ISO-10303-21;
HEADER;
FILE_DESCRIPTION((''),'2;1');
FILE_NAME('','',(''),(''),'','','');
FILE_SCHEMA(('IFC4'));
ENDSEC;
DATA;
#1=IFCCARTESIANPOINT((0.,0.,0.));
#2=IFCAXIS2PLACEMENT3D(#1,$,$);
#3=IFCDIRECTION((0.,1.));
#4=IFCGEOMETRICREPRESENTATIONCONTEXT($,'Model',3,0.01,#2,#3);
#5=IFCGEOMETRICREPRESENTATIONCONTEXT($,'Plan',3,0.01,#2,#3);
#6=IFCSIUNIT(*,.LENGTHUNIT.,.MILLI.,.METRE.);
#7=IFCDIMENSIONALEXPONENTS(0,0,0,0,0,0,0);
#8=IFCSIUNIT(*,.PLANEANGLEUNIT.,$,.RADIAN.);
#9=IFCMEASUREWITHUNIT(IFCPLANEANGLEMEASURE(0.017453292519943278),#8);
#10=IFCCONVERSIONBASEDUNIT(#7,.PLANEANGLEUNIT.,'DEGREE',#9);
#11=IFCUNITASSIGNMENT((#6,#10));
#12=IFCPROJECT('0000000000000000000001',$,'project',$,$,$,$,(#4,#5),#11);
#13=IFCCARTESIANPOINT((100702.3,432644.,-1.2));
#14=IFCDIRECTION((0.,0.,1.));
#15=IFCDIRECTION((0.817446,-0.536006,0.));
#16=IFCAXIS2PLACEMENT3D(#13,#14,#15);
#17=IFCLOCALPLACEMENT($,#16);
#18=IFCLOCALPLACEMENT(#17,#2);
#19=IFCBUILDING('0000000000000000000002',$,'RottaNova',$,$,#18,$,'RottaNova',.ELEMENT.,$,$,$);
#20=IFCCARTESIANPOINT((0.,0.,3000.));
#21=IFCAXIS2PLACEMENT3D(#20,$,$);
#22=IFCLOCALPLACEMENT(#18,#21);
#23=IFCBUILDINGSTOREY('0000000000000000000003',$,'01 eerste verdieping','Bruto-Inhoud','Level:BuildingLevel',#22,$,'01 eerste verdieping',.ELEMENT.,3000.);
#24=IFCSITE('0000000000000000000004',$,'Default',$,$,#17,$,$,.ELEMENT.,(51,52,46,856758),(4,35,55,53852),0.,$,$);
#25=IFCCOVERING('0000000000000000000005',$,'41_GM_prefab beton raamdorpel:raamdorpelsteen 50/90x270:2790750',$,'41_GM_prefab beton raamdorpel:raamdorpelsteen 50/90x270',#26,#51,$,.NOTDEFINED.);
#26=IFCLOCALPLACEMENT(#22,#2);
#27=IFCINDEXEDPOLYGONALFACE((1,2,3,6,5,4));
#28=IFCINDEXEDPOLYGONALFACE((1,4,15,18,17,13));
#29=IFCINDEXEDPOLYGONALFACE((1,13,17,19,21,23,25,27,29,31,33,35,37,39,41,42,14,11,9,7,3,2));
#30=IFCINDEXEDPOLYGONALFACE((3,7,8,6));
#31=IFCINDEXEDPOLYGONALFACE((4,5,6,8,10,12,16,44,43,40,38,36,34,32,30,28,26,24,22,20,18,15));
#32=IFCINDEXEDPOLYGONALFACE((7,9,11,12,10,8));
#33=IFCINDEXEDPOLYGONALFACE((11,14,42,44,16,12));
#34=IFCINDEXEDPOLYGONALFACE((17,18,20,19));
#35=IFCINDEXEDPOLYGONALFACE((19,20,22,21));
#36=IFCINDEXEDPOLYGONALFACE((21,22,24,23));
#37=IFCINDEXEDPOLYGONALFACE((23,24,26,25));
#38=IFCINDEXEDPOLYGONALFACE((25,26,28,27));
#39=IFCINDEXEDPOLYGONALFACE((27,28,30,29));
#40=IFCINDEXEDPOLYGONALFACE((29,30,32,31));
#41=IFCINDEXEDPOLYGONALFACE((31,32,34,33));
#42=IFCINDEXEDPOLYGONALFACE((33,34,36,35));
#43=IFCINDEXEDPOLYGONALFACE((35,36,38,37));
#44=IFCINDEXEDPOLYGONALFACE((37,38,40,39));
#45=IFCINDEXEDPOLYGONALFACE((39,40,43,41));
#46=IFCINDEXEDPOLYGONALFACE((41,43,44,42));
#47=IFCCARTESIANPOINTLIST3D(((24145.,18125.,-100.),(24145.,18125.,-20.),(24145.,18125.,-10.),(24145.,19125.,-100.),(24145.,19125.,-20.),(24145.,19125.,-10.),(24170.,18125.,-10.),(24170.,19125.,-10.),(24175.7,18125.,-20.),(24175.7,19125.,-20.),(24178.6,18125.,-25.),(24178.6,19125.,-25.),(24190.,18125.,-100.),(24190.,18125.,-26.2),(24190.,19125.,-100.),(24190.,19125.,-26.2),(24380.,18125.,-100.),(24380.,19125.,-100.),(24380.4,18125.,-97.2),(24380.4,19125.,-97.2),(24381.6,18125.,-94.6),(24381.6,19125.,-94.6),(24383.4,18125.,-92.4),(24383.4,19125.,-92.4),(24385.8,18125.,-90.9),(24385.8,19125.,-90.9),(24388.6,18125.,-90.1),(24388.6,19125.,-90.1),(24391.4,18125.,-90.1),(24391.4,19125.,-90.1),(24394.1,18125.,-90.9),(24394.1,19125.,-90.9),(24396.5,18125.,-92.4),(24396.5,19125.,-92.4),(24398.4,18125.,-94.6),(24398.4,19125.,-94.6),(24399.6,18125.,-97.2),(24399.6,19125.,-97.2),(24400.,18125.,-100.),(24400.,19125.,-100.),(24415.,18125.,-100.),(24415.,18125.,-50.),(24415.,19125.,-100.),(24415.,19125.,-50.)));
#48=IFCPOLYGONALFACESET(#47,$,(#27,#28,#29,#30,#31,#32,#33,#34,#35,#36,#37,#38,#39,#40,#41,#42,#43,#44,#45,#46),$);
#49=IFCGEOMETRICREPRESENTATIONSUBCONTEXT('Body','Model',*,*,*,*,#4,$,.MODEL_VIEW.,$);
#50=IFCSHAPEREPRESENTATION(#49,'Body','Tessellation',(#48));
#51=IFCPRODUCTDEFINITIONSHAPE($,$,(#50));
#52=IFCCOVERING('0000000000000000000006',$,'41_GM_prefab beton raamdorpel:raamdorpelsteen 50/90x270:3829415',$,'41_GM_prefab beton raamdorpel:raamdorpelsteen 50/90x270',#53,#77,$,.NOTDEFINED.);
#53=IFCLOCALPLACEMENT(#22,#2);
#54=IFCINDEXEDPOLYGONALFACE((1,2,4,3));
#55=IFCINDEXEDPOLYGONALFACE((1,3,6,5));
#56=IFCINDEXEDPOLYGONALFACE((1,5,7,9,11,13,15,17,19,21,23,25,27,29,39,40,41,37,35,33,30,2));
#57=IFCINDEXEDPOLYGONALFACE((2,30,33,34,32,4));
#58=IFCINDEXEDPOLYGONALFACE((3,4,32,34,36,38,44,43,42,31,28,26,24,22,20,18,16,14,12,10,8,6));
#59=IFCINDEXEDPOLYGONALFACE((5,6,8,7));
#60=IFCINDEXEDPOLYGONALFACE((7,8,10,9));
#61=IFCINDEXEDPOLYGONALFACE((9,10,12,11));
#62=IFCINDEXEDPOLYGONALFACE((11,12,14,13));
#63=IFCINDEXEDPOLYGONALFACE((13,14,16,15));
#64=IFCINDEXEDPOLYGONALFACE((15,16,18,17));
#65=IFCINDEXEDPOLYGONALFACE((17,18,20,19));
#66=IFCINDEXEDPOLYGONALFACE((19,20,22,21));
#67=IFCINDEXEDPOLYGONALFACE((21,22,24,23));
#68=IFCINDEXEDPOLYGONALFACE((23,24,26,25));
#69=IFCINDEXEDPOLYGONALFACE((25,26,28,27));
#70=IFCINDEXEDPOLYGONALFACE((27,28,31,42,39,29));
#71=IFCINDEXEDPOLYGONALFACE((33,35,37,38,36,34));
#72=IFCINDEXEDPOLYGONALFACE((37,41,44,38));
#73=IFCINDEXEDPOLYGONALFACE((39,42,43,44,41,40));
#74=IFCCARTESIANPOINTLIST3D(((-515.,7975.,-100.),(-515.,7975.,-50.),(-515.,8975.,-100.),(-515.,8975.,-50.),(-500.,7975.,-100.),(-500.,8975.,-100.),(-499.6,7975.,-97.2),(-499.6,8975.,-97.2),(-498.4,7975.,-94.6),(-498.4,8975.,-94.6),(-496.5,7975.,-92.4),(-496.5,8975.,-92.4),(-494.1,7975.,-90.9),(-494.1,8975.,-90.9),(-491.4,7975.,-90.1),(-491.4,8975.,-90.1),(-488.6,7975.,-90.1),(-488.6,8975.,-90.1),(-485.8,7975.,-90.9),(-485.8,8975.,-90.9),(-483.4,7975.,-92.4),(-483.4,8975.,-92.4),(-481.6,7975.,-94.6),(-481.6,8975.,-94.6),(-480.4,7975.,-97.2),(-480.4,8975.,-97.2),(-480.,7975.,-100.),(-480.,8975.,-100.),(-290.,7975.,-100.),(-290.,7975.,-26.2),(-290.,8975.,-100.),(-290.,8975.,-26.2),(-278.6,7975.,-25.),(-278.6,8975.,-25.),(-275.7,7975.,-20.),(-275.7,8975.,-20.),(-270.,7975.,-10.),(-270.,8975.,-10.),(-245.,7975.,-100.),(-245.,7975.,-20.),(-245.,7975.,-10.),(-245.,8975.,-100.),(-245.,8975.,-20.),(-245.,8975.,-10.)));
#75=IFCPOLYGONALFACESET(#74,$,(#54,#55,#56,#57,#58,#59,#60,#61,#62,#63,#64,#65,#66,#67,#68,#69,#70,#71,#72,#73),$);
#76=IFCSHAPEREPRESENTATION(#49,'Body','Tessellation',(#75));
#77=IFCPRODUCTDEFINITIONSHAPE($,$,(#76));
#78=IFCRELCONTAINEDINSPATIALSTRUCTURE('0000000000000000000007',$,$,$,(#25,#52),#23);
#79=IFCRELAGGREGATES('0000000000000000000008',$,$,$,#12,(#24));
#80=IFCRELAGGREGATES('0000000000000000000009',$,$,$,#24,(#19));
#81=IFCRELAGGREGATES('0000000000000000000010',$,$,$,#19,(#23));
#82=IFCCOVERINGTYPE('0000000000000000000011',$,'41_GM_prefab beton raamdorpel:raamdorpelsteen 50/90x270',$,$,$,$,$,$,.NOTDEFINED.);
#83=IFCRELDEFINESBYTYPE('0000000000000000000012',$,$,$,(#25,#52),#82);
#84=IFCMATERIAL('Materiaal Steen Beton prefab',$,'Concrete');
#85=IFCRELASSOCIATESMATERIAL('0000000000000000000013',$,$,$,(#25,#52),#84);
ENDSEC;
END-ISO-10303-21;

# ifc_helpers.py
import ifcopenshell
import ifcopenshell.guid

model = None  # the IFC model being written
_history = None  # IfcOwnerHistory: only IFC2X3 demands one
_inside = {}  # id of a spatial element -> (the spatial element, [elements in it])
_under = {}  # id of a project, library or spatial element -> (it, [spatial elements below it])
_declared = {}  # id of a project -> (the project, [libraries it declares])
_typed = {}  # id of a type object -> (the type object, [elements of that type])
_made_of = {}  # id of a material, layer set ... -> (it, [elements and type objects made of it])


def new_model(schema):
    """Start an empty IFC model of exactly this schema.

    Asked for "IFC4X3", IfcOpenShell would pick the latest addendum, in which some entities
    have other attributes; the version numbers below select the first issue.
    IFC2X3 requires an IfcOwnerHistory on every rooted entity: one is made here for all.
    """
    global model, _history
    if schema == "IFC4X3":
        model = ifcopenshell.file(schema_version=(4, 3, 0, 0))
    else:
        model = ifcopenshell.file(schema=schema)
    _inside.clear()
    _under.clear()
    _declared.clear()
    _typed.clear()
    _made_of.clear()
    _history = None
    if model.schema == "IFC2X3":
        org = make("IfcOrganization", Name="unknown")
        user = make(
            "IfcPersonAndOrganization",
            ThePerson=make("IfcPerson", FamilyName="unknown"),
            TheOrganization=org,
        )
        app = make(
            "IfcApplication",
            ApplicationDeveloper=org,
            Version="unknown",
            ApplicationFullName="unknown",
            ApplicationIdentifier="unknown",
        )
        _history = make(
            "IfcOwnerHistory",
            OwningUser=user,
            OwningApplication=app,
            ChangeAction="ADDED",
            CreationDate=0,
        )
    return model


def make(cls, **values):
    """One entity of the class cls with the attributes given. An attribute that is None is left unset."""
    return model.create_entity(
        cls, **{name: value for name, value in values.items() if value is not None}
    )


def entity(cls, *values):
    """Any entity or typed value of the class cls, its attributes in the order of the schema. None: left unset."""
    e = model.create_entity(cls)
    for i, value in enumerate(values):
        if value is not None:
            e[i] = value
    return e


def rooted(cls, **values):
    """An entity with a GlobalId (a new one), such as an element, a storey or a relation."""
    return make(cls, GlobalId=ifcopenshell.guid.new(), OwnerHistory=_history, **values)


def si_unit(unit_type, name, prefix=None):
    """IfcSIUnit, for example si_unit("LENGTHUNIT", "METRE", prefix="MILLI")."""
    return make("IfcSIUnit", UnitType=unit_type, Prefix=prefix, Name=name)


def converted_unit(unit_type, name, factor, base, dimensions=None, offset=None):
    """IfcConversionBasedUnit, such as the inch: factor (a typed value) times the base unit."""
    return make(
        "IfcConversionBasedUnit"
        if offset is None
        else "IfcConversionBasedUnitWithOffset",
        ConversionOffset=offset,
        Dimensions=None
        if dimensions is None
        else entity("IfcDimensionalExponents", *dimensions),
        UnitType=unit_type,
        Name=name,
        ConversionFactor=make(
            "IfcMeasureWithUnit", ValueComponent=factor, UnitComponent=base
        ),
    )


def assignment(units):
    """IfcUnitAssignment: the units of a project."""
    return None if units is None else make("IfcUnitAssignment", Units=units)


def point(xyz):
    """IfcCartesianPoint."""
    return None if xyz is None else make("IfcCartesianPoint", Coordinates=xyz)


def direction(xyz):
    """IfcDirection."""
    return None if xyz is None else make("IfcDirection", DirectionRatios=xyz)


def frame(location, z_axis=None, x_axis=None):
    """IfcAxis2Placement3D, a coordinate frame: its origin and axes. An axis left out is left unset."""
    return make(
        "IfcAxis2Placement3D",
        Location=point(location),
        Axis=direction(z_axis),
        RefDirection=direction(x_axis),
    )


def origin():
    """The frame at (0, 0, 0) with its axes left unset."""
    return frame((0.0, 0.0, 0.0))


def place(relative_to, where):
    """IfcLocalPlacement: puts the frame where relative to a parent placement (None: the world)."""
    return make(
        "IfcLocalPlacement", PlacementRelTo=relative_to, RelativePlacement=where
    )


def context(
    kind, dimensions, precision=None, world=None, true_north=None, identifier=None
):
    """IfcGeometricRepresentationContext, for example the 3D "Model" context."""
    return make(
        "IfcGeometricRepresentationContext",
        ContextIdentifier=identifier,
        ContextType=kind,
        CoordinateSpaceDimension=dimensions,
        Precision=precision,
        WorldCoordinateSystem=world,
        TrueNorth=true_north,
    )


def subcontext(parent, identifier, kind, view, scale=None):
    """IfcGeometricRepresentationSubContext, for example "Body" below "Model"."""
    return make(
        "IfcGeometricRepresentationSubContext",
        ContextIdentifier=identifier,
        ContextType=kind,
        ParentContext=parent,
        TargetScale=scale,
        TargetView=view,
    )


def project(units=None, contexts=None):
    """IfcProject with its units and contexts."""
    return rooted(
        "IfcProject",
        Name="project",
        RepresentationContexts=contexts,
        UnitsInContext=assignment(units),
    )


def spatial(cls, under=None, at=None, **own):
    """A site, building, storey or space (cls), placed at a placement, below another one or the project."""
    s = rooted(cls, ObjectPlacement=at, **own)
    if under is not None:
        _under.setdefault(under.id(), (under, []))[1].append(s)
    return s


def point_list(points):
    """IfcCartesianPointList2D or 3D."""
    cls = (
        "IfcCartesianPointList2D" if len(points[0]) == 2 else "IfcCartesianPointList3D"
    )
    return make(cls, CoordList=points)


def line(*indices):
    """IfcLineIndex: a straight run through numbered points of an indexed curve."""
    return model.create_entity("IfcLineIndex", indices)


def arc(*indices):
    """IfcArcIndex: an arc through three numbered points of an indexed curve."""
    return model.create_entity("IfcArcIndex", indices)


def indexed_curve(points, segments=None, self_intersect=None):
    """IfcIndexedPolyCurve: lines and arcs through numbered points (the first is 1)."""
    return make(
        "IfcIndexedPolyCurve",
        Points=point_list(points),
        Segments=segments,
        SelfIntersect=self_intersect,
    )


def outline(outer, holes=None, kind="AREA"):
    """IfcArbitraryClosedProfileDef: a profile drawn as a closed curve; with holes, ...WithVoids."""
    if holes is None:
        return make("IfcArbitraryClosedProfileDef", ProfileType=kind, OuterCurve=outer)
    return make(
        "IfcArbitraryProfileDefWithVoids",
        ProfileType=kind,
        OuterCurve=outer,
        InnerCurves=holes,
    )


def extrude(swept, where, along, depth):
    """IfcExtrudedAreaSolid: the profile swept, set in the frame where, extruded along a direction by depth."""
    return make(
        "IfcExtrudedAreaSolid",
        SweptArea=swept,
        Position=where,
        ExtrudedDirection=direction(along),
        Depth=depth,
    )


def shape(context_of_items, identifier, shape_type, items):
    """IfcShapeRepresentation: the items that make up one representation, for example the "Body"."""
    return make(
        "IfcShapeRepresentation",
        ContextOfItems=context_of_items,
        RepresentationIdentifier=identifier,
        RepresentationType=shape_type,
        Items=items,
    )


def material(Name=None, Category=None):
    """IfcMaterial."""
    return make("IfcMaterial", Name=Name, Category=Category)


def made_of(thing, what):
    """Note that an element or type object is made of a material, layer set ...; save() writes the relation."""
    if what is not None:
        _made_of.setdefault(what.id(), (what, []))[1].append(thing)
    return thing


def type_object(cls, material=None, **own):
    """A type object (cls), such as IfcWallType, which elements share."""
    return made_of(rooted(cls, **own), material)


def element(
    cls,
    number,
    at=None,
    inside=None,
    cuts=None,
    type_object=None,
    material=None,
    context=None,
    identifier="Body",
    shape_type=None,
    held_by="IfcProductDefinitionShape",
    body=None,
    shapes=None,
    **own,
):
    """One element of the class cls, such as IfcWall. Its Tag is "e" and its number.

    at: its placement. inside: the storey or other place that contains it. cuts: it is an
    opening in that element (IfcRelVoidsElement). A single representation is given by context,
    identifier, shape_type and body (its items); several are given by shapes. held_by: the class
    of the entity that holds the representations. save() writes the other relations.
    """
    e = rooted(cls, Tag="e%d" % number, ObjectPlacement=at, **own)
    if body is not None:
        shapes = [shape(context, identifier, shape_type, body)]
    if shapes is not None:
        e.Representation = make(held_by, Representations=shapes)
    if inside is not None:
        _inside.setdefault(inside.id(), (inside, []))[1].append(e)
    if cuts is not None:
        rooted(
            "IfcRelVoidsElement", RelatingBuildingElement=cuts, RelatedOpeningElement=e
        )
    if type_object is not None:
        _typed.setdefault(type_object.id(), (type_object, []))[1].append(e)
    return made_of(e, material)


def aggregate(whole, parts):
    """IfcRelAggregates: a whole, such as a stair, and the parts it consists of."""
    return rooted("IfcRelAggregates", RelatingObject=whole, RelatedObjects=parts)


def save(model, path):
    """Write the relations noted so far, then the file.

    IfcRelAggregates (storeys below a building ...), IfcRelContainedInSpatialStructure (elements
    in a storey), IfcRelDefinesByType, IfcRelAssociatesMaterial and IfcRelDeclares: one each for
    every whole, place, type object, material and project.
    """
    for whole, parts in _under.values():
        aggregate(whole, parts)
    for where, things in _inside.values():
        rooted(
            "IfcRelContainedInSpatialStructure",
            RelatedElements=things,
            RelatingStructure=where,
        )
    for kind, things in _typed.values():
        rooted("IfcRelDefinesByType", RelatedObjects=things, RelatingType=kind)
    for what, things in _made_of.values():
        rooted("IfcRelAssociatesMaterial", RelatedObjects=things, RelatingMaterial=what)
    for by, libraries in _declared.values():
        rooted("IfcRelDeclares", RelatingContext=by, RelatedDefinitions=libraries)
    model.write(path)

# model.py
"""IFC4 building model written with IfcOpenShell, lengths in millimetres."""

from ifc_helpers import new_model, entity, si_unit, converted_unit, direction, frame, origin, place, context, subcontext, project, spatial, line, arc, indexed_curve, outline, extrude, material, type_object, element, save


model = new_model("IFC4")

# Units and contexts
model_context = context("Model", 3, precision=0.01, world=origin(), true_north=direction((0.0, 1.0)))
plan_context = context("Plan", 3, precision=0.01, world=origin(), true_north=direction((0.0, 1.0)))
body_context = subcontext(model_context, "Body", "Model", "MODEL_VIEW")
ifc_project = project(units=[si_unit("LENGTHUNIT", "METRE", prefix="MILLI"), converted_unit("PLANEANGLEUNIT", "DEGREE", entity("IfcPlaneAngleMeasure", 0.017453292519943278), si_unit("PLANEANGLEUNIT", "RADIAN"), dimensions=[0, 0, 0, 0, 0, 0, 0])], contexts=[model_context, plan_context])

# Site, building, storey
site_placement = place(None, frame((100702.3, 432644.0, -1.2), z_axis=(0.0, 0.0, 1.0), x_axis=(0.817446, -0.536006, 0.0)))
site = spatial("IfcSite", under=ifc_project, at=site_placement, Name="Default", CompositionType="ELEMENT", RefLatitude=(51, 52, 46, 856758), RefLongitude=(4, 35, 55, 53852), RefElevation=0.0)
building_placement = place(site_placement, origin())
building = spatial("IfcBuilding", under=site, at=building_placement, Name="RottaNova", LongName="RottaNova", CompositionType="ELEMENT")
storey_placement = place(building_placement, frame((0.0, 0.0, 3000.0)))
storey = spatial("IfcBuildingStorey", under=building, at=storey_placement, Name="01 eerste verdieping", Description="Bruto-Inhoud", ObjectType="Level:BuildingLevel", LongName="01 eerste verdieping", CompositionType="ELEMENT", Elevation=3000.0)

# Coverings
ifc_material_1 = material(Name="Materiaal Steen Beton prefab", Category="Concrete")
covering_type_1 = type_object("IfcCoveringType", Name="41_GM_prefab beton raamdorpel:raamdorpelsteen 50/90x270", PredefinedType="NOTDEFINED")
covering_1_placement = place(storey_placement, origin())
element("IfcCovering", 1, at=covering_1_placement, inside=storey, type_object=covering_type_1, material=ifc_material_1, Name="41_GM_prefab beton raamdorpel:raamdorpelsteen 50/90x270:2790750", ObjectType="41_GM_prefab beton raamdorpel:raamdorpelsteen 50/90x270", PredefinedType="NOTDEFINED", context=body_context, shape_type="SweptSolid", body=[
    extrude(outline(indexed_curve([(-77.0, -43.1), (-89.5, -64.7), (-80.8, -69.7), (-11.5, -109.7), (11.0, -70.7), (106.0, 93.8), (102.3, 107.5), (116.0, 111.1), (123.5, 124.1), (80.2, 149.1), (-52.9, -33.8), (-59.6, -43.1), (-65.4, -43.1)], segments=[line(1, 2, 3, 4, 5, 6), arc(6, 7, 8), line(8, 9, 10, 11, 12, 13, 1)], self_intersect=False)), frame((24245.8, 18125.0, -55.1), z_axis=(0.0, -1.0, 0.0), x_axis=(0.5, 0.0, -0.866025)), (0.0, 0.0, -1.0), 1000.0),
])
covering_2_placement = place(storey_placement, origin())
element("IfcCovering", 2, at=covering_2_placement, inside=storey, type_object=covering_type_1, material=ifc_material_1, Name="41_GM_prefab beton raamdorpel:raamdorpelsteen 50/90x270:3829415", ObjectType="41_GM_prefab beton raamdorpel:raamdorpelsteen 50/90x270", PredefinedType="NOTDEFINED", context=body_context, shape_type="SweptSolid", body=[
    extrude(outline(indexed_curve([(75.8, -45.1), (100.8, -45.1), (100.8, -35.1), (100.8, 44.9), (55.8, 44.9), (-134.2, 44.9), (-144.2, 34.9), (-154.2, 44.9), (-169.2, 44.9), (-169.2, -5.1), (55.8, -28.9), (67.1, -30.1), (70.0, -35.1)], segments=[line(1, 2, 3, 4, 5, 6), arc(6, 7, 8), line(8, 9, 10, 11, 12, 13, 1)], self_intersect=False)), frame((-345.8, 7975.0, -55.1), z_axis=(0.0, 1.0, 0.0), x_axis=(1.0, 0.0, 0.0)), (0.0, 0.0, 1.0), 1000.0),
])

save(model, "model.ifc")
